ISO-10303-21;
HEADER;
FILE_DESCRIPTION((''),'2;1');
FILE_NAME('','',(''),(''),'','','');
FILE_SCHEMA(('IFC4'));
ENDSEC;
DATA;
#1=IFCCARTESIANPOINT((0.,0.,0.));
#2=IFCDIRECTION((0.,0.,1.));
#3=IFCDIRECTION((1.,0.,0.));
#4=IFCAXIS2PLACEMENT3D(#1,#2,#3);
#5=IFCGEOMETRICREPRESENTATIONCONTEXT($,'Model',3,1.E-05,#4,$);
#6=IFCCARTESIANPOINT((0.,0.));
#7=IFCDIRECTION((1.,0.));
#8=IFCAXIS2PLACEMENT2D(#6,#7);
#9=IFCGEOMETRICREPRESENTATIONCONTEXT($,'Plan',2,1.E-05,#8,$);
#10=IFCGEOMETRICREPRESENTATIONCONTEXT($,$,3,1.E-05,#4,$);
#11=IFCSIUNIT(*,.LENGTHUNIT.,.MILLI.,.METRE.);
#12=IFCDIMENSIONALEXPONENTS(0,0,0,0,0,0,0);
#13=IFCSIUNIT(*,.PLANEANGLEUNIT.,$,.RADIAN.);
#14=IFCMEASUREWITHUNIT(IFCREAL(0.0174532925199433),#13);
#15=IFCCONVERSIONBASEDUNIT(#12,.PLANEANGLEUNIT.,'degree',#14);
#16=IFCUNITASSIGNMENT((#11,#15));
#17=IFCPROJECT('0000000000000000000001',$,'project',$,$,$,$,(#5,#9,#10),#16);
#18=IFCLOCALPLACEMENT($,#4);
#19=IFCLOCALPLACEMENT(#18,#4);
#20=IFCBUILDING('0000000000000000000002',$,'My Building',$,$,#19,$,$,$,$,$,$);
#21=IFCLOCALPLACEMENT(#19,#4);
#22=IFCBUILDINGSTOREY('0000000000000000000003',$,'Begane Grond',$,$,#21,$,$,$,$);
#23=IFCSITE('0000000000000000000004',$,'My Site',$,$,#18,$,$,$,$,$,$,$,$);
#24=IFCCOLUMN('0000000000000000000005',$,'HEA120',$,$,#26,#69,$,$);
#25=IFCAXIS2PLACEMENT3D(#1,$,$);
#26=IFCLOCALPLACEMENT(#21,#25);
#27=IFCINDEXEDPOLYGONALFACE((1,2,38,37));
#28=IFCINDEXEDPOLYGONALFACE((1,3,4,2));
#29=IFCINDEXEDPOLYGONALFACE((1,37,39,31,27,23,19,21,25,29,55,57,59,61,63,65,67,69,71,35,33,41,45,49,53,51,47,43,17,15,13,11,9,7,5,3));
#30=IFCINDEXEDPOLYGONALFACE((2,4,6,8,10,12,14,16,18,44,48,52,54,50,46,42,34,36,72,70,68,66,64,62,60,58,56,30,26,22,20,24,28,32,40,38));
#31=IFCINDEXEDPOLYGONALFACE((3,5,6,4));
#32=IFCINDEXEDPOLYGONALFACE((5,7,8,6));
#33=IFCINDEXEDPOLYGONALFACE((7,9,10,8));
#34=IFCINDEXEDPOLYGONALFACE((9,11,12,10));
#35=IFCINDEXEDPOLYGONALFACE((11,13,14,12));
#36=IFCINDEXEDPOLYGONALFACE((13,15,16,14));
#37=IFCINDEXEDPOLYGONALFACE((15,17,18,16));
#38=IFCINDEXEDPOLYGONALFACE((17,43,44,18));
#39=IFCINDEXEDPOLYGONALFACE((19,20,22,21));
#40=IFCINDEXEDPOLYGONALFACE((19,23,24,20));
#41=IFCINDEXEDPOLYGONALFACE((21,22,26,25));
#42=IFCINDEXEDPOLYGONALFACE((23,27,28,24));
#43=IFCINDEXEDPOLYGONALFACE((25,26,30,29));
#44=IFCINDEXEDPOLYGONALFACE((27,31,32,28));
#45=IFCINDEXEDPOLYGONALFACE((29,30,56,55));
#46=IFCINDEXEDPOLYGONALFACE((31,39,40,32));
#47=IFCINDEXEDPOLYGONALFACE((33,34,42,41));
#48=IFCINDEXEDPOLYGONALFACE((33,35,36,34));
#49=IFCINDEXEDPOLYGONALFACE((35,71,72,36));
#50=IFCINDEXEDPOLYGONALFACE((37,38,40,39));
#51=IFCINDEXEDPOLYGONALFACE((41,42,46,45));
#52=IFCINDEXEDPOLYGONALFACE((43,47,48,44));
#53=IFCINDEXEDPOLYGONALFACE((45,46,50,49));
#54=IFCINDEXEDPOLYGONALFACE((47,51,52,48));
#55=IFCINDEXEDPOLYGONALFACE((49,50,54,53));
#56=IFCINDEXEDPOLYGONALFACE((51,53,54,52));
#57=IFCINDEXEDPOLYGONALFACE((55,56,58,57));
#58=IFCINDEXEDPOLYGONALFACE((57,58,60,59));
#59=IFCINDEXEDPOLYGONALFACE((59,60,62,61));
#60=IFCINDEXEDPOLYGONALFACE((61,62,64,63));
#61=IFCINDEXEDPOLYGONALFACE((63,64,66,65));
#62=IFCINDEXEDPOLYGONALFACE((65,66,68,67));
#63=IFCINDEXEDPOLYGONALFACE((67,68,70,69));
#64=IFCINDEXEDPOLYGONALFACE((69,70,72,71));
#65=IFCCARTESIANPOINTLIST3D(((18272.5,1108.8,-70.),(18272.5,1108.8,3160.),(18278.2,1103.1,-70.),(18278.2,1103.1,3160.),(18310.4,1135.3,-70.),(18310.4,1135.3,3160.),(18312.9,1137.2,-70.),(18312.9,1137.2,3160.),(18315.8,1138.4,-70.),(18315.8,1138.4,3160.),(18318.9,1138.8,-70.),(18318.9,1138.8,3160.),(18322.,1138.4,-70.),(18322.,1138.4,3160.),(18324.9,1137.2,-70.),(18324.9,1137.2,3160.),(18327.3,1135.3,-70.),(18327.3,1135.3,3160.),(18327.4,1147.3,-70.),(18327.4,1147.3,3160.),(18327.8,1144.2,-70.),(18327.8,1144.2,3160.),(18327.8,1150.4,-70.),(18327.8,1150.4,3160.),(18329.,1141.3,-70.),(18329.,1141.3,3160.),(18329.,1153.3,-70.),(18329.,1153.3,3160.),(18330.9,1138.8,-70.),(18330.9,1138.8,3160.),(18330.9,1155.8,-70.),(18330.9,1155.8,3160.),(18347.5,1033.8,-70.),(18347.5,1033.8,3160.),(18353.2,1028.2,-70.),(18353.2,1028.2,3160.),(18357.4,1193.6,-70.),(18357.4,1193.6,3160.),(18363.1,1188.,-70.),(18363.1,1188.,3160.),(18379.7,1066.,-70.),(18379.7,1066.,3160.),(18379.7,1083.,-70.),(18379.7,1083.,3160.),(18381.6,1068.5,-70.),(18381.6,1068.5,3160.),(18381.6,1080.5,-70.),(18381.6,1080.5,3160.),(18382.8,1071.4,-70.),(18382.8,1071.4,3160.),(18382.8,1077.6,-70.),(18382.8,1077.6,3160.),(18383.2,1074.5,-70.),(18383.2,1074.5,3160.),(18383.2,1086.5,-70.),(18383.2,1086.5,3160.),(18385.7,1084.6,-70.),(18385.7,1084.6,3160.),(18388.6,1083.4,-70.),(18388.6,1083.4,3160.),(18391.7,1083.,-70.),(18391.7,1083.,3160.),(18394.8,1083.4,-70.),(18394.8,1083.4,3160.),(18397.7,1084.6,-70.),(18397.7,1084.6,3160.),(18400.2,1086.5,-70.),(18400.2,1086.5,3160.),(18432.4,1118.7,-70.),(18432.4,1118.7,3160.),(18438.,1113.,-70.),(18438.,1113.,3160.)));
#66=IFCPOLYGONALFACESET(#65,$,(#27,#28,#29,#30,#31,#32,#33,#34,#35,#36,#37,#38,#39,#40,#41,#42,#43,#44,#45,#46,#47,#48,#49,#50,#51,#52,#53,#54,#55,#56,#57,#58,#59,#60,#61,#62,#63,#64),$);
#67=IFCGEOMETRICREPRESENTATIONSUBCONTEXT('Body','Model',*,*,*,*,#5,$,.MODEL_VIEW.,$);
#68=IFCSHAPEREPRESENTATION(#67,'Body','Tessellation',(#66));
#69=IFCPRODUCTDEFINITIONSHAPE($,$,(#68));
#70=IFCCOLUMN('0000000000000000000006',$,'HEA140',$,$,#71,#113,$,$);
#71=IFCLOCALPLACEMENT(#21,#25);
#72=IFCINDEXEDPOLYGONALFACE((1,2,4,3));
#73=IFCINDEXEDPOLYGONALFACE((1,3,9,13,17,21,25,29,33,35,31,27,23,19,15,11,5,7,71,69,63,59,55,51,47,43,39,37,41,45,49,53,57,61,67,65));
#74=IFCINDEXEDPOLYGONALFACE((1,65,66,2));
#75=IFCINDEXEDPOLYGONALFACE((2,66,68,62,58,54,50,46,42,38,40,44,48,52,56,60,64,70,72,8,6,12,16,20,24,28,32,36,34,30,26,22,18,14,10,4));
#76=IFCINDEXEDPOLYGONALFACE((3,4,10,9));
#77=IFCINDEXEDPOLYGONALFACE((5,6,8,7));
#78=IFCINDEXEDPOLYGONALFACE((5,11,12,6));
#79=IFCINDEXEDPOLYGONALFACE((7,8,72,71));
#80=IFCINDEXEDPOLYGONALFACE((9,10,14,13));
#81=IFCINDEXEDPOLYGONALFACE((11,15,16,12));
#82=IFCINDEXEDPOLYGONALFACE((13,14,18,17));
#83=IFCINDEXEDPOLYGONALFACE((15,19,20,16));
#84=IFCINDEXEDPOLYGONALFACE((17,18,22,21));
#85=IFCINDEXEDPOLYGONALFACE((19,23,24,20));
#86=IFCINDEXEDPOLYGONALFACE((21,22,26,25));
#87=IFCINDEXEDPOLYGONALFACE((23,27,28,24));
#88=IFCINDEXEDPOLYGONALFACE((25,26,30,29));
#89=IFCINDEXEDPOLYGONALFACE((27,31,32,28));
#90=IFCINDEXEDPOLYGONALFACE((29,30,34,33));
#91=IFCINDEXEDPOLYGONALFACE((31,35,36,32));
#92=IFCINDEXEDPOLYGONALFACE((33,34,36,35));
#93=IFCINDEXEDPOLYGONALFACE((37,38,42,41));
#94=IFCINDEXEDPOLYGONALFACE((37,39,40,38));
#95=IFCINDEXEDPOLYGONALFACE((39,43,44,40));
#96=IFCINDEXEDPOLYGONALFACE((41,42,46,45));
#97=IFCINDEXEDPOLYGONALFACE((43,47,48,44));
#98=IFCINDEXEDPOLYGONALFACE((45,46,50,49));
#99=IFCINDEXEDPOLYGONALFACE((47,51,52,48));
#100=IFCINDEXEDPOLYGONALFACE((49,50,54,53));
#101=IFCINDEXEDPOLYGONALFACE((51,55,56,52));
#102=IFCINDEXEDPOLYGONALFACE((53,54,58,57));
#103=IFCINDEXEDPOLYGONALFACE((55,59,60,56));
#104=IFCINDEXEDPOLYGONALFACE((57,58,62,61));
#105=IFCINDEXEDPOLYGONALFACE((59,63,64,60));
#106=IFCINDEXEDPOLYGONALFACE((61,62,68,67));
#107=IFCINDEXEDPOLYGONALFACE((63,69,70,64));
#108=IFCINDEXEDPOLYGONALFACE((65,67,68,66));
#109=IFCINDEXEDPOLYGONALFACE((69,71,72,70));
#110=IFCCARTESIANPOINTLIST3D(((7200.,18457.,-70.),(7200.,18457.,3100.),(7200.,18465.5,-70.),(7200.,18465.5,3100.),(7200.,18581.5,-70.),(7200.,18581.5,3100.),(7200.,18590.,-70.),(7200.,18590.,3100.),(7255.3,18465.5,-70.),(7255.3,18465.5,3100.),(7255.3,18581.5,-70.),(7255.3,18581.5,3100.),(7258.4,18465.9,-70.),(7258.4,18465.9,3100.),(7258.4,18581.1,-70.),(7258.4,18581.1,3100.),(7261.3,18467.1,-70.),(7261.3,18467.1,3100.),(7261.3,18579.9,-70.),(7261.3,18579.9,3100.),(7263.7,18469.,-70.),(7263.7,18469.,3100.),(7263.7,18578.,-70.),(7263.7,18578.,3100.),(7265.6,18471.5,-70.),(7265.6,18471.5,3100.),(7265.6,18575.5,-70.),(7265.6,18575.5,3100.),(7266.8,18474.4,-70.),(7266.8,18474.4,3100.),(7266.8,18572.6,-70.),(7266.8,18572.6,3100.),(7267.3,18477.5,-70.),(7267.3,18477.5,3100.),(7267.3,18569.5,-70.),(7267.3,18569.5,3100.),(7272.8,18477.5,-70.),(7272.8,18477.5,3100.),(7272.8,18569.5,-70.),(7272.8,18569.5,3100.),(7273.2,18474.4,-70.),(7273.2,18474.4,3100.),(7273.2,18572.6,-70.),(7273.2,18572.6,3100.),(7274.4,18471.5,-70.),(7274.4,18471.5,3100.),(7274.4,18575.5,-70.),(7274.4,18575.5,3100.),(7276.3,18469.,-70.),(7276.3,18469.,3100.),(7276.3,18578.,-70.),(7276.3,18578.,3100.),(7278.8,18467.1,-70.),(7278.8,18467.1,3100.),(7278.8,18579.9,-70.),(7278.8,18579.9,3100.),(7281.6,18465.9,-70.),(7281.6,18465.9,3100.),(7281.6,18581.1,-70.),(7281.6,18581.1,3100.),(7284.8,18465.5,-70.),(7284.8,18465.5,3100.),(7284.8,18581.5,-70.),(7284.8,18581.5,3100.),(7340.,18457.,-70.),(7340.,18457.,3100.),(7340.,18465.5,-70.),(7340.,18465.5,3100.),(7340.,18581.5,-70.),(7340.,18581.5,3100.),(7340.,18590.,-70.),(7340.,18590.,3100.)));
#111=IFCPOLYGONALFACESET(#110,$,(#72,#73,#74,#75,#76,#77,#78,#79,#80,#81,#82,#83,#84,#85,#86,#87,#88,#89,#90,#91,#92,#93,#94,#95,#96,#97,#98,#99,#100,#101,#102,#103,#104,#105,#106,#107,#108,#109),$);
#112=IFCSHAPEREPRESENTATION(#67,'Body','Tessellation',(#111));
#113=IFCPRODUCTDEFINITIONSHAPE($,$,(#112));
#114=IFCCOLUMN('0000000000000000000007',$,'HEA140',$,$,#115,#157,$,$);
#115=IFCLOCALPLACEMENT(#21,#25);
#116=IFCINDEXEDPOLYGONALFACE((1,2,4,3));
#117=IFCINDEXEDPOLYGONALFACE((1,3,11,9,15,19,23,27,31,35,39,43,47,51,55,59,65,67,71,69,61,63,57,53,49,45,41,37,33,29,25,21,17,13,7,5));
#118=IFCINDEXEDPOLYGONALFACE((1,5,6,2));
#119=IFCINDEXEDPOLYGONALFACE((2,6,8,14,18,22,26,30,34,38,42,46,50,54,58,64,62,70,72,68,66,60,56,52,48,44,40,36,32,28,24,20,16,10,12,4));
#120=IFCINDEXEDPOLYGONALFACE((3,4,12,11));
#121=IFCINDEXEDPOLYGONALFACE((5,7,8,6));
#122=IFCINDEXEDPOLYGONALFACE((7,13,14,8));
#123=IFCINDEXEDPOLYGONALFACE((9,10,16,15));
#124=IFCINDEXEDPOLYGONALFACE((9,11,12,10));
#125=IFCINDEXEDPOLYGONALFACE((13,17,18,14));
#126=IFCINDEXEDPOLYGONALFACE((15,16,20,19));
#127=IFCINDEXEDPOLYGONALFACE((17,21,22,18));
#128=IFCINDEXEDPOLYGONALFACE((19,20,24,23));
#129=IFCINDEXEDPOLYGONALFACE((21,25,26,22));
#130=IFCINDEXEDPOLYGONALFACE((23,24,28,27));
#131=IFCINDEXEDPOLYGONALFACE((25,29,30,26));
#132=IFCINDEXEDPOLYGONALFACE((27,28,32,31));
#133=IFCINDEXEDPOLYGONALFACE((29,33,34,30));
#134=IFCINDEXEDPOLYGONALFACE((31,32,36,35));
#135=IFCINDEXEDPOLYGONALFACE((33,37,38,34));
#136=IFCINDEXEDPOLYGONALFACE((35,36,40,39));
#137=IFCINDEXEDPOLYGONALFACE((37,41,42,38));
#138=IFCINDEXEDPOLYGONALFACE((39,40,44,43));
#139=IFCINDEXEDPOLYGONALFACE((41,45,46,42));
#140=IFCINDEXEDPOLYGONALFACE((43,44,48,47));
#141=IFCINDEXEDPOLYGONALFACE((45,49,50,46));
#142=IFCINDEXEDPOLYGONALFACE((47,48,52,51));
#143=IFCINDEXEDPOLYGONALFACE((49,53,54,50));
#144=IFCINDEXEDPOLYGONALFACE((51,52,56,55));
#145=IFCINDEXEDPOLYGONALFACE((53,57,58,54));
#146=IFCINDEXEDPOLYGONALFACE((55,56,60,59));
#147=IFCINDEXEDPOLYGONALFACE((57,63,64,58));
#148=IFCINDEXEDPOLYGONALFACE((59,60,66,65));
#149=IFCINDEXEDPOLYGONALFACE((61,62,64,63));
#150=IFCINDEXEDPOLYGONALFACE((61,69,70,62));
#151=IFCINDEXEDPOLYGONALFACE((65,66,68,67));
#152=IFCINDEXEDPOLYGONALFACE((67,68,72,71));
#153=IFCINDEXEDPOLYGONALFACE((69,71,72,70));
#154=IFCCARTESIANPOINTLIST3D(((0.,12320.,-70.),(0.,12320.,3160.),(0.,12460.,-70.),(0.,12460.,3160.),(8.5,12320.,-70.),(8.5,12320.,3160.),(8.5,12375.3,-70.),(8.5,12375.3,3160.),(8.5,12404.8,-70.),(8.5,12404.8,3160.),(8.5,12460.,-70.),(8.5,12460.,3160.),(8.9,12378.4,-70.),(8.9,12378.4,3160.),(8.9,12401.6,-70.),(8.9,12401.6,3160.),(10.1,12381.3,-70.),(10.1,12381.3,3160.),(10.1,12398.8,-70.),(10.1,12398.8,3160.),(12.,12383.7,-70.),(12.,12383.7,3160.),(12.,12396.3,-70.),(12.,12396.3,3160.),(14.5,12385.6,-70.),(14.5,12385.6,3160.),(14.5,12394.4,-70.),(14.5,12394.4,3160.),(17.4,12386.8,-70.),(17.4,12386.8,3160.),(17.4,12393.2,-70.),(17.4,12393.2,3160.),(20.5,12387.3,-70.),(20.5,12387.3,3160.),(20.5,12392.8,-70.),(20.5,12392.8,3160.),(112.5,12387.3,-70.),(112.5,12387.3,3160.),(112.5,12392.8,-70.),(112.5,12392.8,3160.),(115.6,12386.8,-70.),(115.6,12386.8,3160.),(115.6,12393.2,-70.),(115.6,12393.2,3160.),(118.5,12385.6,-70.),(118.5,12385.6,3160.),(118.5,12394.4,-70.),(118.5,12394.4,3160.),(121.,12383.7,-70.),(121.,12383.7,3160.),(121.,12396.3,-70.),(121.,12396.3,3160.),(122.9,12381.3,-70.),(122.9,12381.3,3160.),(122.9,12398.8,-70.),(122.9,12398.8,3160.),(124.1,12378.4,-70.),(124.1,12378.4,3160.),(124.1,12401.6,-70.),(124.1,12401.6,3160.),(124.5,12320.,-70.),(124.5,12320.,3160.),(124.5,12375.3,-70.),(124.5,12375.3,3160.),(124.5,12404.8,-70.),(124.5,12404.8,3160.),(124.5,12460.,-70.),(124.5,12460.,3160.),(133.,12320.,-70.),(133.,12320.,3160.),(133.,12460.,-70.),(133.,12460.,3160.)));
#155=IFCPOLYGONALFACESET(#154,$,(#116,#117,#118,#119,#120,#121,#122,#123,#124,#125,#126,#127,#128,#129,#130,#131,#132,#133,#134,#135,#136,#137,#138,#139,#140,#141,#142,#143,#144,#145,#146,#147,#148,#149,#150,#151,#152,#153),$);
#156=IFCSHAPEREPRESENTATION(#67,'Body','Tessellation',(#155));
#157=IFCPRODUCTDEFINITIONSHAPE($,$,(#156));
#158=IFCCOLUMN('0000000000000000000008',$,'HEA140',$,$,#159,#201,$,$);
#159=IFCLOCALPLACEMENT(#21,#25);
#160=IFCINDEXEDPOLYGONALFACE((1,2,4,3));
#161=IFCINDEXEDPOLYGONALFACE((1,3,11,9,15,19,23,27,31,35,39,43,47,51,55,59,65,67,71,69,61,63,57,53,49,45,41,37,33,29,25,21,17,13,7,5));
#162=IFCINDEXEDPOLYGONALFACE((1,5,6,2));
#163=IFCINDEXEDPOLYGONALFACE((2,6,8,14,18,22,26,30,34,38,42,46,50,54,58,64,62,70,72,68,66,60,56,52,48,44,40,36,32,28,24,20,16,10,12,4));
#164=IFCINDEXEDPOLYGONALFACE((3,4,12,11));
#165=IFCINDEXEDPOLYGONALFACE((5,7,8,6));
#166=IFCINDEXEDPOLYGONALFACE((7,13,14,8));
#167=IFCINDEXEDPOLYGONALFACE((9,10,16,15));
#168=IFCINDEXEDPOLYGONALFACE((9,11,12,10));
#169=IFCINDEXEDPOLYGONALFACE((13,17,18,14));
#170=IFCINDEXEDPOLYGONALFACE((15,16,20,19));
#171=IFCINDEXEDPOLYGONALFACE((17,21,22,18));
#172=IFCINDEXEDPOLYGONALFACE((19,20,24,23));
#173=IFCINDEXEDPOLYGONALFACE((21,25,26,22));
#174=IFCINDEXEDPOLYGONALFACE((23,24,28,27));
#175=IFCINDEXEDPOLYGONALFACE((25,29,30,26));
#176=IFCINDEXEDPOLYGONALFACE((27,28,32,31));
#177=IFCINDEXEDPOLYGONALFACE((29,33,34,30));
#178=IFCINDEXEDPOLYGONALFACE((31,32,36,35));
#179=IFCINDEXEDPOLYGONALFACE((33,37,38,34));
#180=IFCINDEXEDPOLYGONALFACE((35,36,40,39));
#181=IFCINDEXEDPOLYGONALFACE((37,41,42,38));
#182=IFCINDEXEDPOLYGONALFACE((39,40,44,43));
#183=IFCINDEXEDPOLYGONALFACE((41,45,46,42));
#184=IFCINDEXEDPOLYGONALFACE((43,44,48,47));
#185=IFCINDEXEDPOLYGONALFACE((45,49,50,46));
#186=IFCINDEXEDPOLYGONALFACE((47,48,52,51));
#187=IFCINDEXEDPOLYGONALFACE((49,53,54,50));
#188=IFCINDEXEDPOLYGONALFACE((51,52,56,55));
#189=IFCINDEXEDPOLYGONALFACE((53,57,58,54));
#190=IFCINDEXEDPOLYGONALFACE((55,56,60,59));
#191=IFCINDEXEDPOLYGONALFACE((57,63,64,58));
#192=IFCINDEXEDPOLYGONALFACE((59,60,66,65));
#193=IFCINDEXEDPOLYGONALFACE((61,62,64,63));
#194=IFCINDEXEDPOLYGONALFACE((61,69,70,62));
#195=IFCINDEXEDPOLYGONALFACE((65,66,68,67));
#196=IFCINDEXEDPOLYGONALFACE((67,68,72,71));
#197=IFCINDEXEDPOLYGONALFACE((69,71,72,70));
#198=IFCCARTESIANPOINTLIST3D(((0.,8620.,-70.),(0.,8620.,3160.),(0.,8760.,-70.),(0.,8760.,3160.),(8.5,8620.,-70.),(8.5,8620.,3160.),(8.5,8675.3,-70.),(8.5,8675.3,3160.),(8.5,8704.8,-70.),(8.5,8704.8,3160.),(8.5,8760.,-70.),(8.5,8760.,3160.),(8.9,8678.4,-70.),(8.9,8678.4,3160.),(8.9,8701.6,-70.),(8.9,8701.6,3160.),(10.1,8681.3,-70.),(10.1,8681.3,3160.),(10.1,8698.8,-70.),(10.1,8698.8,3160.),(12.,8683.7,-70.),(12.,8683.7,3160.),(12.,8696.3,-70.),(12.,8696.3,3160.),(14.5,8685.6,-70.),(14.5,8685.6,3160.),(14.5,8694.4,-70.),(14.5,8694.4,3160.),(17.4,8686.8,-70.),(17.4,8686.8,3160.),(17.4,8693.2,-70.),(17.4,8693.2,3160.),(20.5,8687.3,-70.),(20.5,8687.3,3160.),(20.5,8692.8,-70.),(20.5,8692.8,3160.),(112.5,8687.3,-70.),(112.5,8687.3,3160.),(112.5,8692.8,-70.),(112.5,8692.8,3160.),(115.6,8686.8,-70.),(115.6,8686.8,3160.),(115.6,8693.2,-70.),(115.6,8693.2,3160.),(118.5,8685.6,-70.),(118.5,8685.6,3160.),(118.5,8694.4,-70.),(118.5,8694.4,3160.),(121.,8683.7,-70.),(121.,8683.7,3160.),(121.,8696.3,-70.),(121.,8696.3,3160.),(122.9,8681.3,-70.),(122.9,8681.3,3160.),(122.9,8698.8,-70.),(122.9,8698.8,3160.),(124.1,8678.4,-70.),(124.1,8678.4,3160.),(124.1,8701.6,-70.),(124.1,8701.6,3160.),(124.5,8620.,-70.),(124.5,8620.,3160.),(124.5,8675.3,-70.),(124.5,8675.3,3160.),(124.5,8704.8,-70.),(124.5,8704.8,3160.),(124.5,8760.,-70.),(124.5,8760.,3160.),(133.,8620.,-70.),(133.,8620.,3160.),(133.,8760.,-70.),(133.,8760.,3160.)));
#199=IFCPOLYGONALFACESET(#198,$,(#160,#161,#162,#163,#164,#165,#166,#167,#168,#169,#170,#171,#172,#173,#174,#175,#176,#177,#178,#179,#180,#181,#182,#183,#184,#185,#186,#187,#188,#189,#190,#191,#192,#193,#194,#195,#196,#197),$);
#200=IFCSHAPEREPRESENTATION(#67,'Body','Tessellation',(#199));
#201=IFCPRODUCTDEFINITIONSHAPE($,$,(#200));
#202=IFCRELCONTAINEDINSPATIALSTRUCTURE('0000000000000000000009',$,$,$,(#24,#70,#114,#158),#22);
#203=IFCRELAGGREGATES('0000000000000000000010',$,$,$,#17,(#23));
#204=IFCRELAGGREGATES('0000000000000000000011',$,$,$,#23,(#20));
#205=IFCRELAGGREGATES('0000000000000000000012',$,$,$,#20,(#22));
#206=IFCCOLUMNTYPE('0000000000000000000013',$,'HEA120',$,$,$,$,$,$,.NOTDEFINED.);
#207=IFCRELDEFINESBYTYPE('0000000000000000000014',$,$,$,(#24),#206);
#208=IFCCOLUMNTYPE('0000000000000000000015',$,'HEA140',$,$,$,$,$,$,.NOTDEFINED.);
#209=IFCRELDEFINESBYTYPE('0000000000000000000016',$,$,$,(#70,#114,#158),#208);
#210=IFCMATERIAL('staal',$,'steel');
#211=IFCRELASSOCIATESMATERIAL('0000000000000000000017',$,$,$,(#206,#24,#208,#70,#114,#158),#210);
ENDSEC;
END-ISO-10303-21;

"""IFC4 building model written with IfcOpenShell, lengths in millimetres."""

from ifc_helpers import new_model, entity, si_unit, converted_unit, frame, origin_with_axes, origin_2d_with_axis, place, context, subcontext, project, spatial, i_section, extrude, material, material_profile, profile_set, profile_usage, type_object, element, save


model = new_model("IFC4")

# Units and contexts
model_context = context("Model", 3, precision=1e-05, world=origin_with_axes())
plan_context = context("Plan", 2, precision=1e-05, world=origin_2d_with_axis())
context_of_model = context(None, 3, precision=1e-05, world=origin_with_axes())
body_context = subcontext(model_context, "Body", "Model", "MODEL_VIEW")
ifc_project = project(units=[si_unit("LENGTHUNIT", "METRE", prefix="MILLI"), converted_unit("PLANEANGLEUNIT", "degree", entity("IfcReal", 0.0174532925199433), si_unit("PLANEANGLEUNIT", "RADIAN"), dimensions=[0, 0, 0, 0, 0, 0, 0])], contexts=[model_context, plan_context, context_of_model])

# Site, building, storey
site_placement = place(None, origin_with_axes())
site = spatial("IfcSite", under=ifc_project, at=site_placement, Name="My Site")
building_placement = place(site_placement, origin_with_axes())
building = spatial("IfcBuilding", under=site, at=building_placement, Name="My Building")
storey_placement = place(building_placement, origin_with_axes())
storey = spatial("IfcBuildingStorey", under=building, at=storey_placement, Name="Begane Grond")

# Columns
ifc_material = material(Name="staal", Category="steel")
ifc_material_profile_1 = material_profile(ifc_material, i_section(OverallWidth=120.0, OverallDepth=114.0, WebThickness=5.0, FlangeThickness=8.0, FilletRadius=12.0))
ifc_profile_set_1 = profile_set([ifc_material_profile_1], Name="HEA120")
column_type_1 = type_object("IfcColumnType", Name="HEA120", PredefinedType="NOTDEFINED", material=ifc_profile_set_1)
ifc_profile_usage_1 = profile_usage(ifc_profile_set_1)
column_1_placement = place(storey_placement, frame((18355.3, 1110.9, -70.0), z_axis=(0.0, 0.0, 1.0), x_axis=(0.707107, 0.707107, 0.0)))
element("IfcColumn", 1, at=column_1_placement, inside=storey, type_object=column_type_1, material=ifc_profile_usage_1, Name="HEA120", context=body_context, shape_type="SweptSolid", body=[
    extrude(i_section(OverallWidth=120.0, OverallDepth=114.0, WebThickness=5.0, FlangeThickness=8.0, FilletRadius=12.0), origin_with_axes(), (0.0, 0.0, 1.0), 3230.0),
])
ifc_material_profile_2 = material_profile(ifc_material, i_section(OverallWidth=140.0, OverallDepth=133.0, WebThickness=5.5, FlangeThickness=8.5, FilletRadius=12.0))
ifc_profile_set_2 = profile_set([ifc_material_profile_2], Name="HEA140")
ifc_profile_usage_2 = profile_usage(ifc_profile_set_2)
column_type_2 = type_object("IfcColumnType", Name="HEA140", PredefinedType="NOTDEFINED", material=ifc_profile_set_2)
column_2_placement = place(storey_placement, frame((7270.0, 18523.5, -70.0), z_axis=(0.0, 0.0, 1.0), x_axis=(1.0, 0.0, 0.0)))
element("IfcColumn", 2, at=column_2_placement, inside=storey, type_object=column_type_2, material=ifc_profile_usage_2, Name="HEA140", context=body_context, shape_type="SweptSolid", body=[
    extrude(i_section(OverallWidth=140.0, OverallDepth=133.0, WebThickness=5.5, FlangeThickness=8.5, FilletRadius=12.0), origin_with_axes(), (0.0, 0.0, 1.0), 3170.0),
])
ifc_profile_usage_3 = profile_usage(ifc_profile_set_2)
column_3_placement = place(storey_placement, frame((66.5, 12390.0, -70.0), z_axis=(0.0, 0.0, 1.0), x_axis=(0.0, 1.0, 0.0)))
element("IfcColumn", 3, at=column_3_placement, inside=storey, type_object=column_type_2, material=ifc_profile_usage_3, Name="HEA140", context=body_context, shape_type="SweptSolid", body=[
    extrude(i_section(OverallWidth=140.0, OverallDepth=133.0, WebThickness=5.5, FlangeThickness=8.5, FilletRadius=12.0), origin_with_axes(), (0.0, 0.0, 1.0), 3230.0),
])
for number, where, z_axis, x_axis, name in (
    (4, (66.5, 8690.0, -70.0), (0.0, 0.0, 1.0), (0.0, 1.0, 0.0), "HEA140"),
):
    element("IfcColumn", number, at=place(storey_placement, frame(where, z_axis=z_axis, x_axis=x_axis)), inside=storey, type_object=column_type_2, material=ifc_material, Name=name, context=body_context, shape_type="SweptSolid", body=[
        extrude(i_section(OverallWidth=140.0, OverallDepth=133.0, WebThickness=5.5, FlangeThickness=8.5, FilletRadius=12.0), origin_with_axes(), (0.0, 0.0, 1.0), 3230.0),
    ])

save(model, "model.ifc")
